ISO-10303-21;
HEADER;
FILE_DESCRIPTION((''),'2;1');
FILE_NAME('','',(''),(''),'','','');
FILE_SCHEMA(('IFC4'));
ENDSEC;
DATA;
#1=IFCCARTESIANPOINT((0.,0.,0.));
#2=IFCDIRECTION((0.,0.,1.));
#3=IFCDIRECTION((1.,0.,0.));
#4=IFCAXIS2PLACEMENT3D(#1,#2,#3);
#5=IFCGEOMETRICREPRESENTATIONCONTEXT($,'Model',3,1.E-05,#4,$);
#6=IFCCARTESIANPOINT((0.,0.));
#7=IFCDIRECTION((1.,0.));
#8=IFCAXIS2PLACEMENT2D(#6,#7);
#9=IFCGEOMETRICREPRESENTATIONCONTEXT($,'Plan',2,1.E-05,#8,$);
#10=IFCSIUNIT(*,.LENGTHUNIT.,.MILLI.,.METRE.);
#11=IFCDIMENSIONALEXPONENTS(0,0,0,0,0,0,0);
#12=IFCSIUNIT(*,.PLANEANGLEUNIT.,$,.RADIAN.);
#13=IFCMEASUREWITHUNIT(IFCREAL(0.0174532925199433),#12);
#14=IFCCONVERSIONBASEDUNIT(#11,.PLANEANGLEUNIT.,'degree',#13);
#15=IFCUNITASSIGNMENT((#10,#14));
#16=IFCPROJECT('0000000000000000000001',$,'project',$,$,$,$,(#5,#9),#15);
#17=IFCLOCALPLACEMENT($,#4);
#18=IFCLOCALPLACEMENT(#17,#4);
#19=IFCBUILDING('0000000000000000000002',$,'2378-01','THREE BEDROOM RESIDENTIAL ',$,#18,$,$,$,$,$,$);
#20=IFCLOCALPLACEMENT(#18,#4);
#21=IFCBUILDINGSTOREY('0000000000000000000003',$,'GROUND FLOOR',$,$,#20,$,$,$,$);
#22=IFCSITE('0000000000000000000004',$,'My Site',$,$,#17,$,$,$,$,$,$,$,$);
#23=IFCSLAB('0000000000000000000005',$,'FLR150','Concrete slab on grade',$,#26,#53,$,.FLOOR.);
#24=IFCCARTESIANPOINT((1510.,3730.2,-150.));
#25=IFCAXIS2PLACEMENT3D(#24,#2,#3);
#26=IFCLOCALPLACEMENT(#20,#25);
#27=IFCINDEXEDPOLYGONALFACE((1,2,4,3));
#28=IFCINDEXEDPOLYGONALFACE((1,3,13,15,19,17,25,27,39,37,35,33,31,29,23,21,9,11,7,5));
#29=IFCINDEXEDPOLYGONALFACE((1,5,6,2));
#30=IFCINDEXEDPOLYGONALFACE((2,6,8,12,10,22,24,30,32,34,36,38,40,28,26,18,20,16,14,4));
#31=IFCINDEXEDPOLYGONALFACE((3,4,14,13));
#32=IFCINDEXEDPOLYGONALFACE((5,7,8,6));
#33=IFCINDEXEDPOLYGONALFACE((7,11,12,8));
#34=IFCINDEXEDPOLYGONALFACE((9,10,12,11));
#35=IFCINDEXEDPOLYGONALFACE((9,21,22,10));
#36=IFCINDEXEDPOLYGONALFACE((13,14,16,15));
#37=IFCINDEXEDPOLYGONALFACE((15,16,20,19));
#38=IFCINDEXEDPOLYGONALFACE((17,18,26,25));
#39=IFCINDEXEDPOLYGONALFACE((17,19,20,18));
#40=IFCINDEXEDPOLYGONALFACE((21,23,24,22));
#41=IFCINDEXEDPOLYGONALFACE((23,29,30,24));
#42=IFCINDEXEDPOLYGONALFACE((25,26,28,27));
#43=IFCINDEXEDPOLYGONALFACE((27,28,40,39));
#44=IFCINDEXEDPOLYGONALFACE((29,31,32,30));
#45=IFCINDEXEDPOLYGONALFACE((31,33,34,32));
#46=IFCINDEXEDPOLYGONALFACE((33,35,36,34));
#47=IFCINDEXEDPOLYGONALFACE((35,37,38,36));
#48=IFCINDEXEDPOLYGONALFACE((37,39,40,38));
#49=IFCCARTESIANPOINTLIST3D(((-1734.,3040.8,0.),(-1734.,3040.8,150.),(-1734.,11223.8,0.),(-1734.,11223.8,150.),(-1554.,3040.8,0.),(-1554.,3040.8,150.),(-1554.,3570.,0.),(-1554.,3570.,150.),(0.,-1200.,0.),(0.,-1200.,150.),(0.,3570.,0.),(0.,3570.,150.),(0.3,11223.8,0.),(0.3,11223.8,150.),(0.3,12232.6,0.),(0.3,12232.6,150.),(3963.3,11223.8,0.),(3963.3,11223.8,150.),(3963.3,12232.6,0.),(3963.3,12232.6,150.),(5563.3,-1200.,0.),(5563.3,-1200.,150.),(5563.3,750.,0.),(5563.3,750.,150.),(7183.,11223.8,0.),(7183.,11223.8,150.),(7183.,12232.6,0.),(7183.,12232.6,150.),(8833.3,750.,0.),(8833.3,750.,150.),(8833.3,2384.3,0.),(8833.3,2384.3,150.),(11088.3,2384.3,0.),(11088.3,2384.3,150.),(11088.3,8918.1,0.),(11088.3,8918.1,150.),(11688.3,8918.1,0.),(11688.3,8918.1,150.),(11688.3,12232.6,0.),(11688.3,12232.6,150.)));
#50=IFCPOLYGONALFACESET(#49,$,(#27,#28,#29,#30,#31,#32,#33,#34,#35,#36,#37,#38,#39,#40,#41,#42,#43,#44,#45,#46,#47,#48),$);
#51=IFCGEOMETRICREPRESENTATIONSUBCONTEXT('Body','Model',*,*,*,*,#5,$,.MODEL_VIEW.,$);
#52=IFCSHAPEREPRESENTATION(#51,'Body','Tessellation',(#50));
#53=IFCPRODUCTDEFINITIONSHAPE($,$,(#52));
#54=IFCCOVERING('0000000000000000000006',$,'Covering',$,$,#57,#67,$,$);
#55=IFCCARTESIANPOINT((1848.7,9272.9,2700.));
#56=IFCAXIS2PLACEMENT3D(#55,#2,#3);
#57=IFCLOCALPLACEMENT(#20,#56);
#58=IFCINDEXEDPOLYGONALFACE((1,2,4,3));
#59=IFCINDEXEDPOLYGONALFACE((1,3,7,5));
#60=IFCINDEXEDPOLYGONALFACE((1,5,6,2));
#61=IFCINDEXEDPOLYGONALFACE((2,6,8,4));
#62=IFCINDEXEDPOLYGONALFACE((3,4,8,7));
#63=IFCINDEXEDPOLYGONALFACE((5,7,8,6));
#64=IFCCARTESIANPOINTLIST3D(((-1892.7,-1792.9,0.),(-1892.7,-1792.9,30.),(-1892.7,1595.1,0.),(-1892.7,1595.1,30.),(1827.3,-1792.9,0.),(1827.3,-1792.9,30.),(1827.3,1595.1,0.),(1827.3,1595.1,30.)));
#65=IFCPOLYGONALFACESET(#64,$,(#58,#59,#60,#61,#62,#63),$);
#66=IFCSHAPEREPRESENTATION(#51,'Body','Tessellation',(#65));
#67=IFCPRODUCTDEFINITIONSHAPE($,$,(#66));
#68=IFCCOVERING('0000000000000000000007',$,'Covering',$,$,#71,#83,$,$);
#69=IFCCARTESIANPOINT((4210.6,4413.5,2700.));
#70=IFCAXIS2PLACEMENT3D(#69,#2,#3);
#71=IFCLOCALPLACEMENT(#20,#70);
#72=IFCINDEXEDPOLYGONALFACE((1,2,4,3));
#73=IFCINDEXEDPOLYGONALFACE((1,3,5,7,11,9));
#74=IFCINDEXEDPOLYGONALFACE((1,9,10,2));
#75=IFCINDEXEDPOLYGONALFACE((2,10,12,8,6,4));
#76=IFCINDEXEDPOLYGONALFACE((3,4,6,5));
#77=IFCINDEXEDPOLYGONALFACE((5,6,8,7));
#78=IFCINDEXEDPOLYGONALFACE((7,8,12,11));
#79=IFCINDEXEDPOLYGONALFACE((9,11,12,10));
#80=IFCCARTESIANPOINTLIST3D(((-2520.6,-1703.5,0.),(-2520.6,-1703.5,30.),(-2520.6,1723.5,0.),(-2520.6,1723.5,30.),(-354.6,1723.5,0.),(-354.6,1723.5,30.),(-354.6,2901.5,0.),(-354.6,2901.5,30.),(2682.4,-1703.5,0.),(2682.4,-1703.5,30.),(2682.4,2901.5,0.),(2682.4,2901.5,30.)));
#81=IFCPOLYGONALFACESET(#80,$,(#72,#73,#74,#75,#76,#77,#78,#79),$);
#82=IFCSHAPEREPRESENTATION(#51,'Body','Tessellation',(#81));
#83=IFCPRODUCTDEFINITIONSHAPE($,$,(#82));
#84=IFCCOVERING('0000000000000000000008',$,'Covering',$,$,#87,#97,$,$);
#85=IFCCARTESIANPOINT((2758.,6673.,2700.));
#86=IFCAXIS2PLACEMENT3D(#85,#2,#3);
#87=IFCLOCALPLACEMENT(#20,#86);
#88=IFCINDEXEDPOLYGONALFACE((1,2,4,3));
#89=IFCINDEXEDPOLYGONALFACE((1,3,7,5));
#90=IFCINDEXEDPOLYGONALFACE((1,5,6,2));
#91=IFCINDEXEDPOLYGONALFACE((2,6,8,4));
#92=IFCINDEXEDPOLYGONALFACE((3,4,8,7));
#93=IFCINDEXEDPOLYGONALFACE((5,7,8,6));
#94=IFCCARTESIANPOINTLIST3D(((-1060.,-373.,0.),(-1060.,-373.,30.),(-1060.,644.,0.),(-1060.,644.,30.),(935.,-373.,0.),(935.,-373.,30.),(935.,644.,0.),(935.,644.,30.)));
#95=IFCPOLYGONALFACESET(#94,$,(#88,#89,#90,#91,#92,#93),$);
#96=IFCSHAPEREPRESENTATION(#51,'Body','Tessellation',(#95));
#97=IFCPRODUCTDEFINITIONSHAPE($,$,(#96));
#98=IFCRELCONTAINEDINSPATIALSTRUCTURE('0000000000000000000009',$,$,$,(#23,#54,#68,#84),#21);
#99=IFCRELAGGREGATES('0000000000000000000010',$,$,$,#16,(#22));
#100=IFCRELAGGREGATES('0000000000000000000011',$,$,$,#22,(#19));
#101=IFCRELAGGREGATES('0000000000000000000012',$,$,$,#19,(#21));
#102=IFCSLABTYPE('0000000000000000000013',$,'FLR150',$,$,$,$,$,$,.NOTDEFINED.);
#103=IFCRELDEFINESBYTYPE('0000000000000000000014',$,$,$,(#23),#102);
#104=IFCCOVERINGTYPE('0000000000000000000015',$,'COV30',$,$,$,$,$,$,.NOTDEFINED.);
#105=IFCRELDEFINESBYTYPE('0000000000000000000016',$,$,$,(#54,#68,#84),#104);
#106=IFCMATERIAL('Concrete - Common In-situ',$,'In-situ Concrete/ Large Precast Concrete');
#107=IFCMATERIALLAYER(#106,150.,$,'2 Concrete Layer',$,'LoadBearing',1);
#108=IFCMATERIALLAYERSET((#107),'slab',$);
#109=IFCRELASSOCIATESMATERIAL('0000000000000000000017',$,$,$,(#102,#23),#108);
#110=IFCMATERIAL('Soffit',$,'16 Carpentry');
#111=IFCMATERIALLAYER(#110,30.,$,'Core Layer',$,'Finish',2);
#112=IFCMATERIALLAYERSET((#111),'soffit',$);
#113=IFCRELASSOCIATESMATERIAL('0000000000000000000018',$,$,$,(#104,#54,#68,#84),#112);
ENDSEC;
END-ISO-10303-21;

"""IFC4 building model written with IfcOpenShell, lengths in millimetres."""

from ifc_helpers import new_model, entity, si_unit, converted_unit, frame, origin_with_axes, origin_2d_with_axis, place, context, subcontext, project, spatial, line, indexed_curve, outline, extrude, material, layer, layer_set, layer_usage, type_object, element, save


model = new_model("IFC4")

# Units and contexts
model_context = context("Model", 3, precision=1e-05, world=origin_with_axes())
plan_context = context("Plan", 2, precision=1e-05, world=origin_2d_with_axis())
body_context_1 = subcontext(model_context, "Body", "Model", "MODEL_VIEW")
ifc_project = project(units=[si_unit("LENGTHUNIT", "METRE", prefix="MILLI"), converted_unit("PLANEANGLEUNIT", "degree", entity("IfcReal", 0.0174532925199433), si_unit("PLANEANGLEUNIT", "RADIAN"), dimensions=[0, 0, 0, 0, 0, 0, 0])], contexts=[model_context, plan_context])

# Site, building, storey
site_placement = place(None, origin_with_axes())
site = spatial("IfcSite", under=ifc_project, at=site_placement, Name="My Site")
building_placement = place(site_placement, origin_with_axes())
building = spatial("IfcBuilding", under=site, at=building_placement, Name="2378-01", Description="THREE BEDROOM RESIDENTIAL ")
storey_placement = place(building_placement, origin_with_axes())
storey = spatial("IfcBuildingStorey", under=building, at=storey_placement, Name="GROUND FLOOR")

# Slab
ifc_material_1 = material(Name="Concrete - Common In-situ", Category="In-situ Concrete/ Large Precast Concrete")
ifc_layer_1 = layer(ifc_material_1, 150.0, Name="2 Concrete Layer", Category="LoadBearing", Priority=1)
ifc_layer_set_1 = layer_set([ifc_layer_1], Name="slab")
ifc_layer_usage_1 = layer_usage(ifc_layer_set_1, "AXIS3", "POSITIVE", 0.0)
slab_type = type_object("IfcSlabType", Name="FLR150", PredefinedType="NOTDEFINED", material=ifc_layer_set_1)
slab_placement = place(storey_placement, frame((1510.0, 3730.2, -150.0), z_axis=(0.0, 0.0, 1.0), x_axis=(1.0, 0.0, 0.0)))
element("IfcSlab", 1, at=slab_placement, inside=storey, type_object=slab_type, material=ifc_layer_usage_1, Name="FLR150", Description="Concrete slab on grade", PredefinedType="FLOOR", context=body_context_1, shape_type="SweptSolid", body=[
    extrude(outline(indexed_curve([(11688.3, 8918.1), (11688.3, 12232.6), (7183.0, 12232.6), (7183.0, 11223.8), (3963.3, 11223.8), (3963.3, 12232.6), (0.3, 12232.6), (0.3, 11223.8), (-1734.0, 11223.8), (-1734.0, 3040.8), (-1554.0, 3040.8), (-1554.0, 3570.0), (0.0, 3570.0), (0.0, -1200.0), (5563.3, -1200.0), (5563.3, 750.0), (8833.3, 750.0), (8833.3, 2384.3), (11088.3, 2384.3), (11088.3, 8918.1)], segments=[line(8, 7), line(7, 6), line(6, 5), line(5, 4), line(4, 3), line(3, 2), line(2, 1), line(1, 20), line(20, 19), line(19, 18), line(18, 17), line(17, 16), line(16, 15), line(15, 14), line(14, 13), line(13, 12), line(12, 11), line(11, 10), line(10, 9), line(9, 8)], self_intersect=False)), None, (0.0, 0.0, 1.0), 150.0),
])

# Coverings
ifc_material_2 = material(Name="Soffit", Category="16 Carpentry")
ifc_layer_2 = layer(ifc_material_2, 30.0, Name="Core Layer", Category="Finish", Priority=2)
ifc_layer_set_2 = layer_set([ifc_layer_2], Name="soffit")
ifc_layer_usage_2 = layer_usage(ifc_layer_set_2, "AXIS3", "POSITIVE", 0.0)
covering_type = type_object("IfcCoveringType", Name="COV30", PredefinedType="NOTDEFINED", material=ifc_layer_set_2)
covering_1_placement = place(storey_placement, frame((1848.7, 9272.9, 2700.0), z_axis=(0.0, 0.0, 1.0), x_axis=(1.0, 0.0, 0.0)))
element("IfcCovering", 2, at=covering_1_placement, inside=storey, type_object=covering_type, material=ifc_layer_usage_2, Name="Covering", context=body_context_1, shape_type="SweptSolid", body=[
    extrude(outline(indexed_curve([(1827.3, -1792.9), (-1892.7, -1792.9), (-1892.7, 1595.1), (1827.3, 1595.1), (1827.3, -1792.9)], segments=[line(1, 2, 3, 4, 5, 1)])), None, (0.0, 0.0, 1.0), 30.0),
])
ifc_layer_usage_3 = layer_usage(ifc_layer_set_2, "AXIS3", "POSITIVE", 0.0)
covering_2_placement = place(storey_placement, frame((4210.6, 4413.5, 2700.0), z_axis=(0.0, 0.0, 1.0), x_axis=(1.0, 0.0, 0.0)))
element("IfcCovering", 3, at=covering_2_placement, inside=storey, type_object=covering_type, material=ifc_layer_usage_3, Name="Covering", context=body_context_1, shape_type="SweptSolid", body=[
    extrude(outline(indexed_curve([(-354.6, 1723.5), (-354.6, 2901.5), (2682.4, 2901.5), (2682.4, -1703.5), (-2520.6, -1703.5), (-2520.6, 1723.5), (-354.6, 1723.5)], segments=[line(1, 2, 3, 4, 5, 6, 7, 1)])), None, (0.0, 0.0, 1.0), 30.0),
])
ifc_layer_usage_4 = layer_usage(ifc_layer_set_2, "AXIS3", "POSITIVE", 0.0)
covering_3_placement = place(storey_placement, frame((2758.0, 6673.0, 2700.0), z_axis=(0.0, 0.0, 1.0), x_axis=(1.0, 0.0, 0.0)))
element("IfcCovering", 4, at=covering_3_placement, inside=storey, type_object=covering_type, material=ifc_layer_usage_4, Name="Covering", context=body_context_1, shape_type="SweptSolid", body=[
    extrude(outline(indexed_curve([(935.0, -373.0), (-1060.0, -373.0), (-1060.0, 644.0), (935.0, 644.0), (935.0, -373.0)], segments=[line(1, 2, 3, 4, 5, 1)])), None, (0.0, 0.0, 1.0), 30.0),
])

save(model, "model.ifc")
